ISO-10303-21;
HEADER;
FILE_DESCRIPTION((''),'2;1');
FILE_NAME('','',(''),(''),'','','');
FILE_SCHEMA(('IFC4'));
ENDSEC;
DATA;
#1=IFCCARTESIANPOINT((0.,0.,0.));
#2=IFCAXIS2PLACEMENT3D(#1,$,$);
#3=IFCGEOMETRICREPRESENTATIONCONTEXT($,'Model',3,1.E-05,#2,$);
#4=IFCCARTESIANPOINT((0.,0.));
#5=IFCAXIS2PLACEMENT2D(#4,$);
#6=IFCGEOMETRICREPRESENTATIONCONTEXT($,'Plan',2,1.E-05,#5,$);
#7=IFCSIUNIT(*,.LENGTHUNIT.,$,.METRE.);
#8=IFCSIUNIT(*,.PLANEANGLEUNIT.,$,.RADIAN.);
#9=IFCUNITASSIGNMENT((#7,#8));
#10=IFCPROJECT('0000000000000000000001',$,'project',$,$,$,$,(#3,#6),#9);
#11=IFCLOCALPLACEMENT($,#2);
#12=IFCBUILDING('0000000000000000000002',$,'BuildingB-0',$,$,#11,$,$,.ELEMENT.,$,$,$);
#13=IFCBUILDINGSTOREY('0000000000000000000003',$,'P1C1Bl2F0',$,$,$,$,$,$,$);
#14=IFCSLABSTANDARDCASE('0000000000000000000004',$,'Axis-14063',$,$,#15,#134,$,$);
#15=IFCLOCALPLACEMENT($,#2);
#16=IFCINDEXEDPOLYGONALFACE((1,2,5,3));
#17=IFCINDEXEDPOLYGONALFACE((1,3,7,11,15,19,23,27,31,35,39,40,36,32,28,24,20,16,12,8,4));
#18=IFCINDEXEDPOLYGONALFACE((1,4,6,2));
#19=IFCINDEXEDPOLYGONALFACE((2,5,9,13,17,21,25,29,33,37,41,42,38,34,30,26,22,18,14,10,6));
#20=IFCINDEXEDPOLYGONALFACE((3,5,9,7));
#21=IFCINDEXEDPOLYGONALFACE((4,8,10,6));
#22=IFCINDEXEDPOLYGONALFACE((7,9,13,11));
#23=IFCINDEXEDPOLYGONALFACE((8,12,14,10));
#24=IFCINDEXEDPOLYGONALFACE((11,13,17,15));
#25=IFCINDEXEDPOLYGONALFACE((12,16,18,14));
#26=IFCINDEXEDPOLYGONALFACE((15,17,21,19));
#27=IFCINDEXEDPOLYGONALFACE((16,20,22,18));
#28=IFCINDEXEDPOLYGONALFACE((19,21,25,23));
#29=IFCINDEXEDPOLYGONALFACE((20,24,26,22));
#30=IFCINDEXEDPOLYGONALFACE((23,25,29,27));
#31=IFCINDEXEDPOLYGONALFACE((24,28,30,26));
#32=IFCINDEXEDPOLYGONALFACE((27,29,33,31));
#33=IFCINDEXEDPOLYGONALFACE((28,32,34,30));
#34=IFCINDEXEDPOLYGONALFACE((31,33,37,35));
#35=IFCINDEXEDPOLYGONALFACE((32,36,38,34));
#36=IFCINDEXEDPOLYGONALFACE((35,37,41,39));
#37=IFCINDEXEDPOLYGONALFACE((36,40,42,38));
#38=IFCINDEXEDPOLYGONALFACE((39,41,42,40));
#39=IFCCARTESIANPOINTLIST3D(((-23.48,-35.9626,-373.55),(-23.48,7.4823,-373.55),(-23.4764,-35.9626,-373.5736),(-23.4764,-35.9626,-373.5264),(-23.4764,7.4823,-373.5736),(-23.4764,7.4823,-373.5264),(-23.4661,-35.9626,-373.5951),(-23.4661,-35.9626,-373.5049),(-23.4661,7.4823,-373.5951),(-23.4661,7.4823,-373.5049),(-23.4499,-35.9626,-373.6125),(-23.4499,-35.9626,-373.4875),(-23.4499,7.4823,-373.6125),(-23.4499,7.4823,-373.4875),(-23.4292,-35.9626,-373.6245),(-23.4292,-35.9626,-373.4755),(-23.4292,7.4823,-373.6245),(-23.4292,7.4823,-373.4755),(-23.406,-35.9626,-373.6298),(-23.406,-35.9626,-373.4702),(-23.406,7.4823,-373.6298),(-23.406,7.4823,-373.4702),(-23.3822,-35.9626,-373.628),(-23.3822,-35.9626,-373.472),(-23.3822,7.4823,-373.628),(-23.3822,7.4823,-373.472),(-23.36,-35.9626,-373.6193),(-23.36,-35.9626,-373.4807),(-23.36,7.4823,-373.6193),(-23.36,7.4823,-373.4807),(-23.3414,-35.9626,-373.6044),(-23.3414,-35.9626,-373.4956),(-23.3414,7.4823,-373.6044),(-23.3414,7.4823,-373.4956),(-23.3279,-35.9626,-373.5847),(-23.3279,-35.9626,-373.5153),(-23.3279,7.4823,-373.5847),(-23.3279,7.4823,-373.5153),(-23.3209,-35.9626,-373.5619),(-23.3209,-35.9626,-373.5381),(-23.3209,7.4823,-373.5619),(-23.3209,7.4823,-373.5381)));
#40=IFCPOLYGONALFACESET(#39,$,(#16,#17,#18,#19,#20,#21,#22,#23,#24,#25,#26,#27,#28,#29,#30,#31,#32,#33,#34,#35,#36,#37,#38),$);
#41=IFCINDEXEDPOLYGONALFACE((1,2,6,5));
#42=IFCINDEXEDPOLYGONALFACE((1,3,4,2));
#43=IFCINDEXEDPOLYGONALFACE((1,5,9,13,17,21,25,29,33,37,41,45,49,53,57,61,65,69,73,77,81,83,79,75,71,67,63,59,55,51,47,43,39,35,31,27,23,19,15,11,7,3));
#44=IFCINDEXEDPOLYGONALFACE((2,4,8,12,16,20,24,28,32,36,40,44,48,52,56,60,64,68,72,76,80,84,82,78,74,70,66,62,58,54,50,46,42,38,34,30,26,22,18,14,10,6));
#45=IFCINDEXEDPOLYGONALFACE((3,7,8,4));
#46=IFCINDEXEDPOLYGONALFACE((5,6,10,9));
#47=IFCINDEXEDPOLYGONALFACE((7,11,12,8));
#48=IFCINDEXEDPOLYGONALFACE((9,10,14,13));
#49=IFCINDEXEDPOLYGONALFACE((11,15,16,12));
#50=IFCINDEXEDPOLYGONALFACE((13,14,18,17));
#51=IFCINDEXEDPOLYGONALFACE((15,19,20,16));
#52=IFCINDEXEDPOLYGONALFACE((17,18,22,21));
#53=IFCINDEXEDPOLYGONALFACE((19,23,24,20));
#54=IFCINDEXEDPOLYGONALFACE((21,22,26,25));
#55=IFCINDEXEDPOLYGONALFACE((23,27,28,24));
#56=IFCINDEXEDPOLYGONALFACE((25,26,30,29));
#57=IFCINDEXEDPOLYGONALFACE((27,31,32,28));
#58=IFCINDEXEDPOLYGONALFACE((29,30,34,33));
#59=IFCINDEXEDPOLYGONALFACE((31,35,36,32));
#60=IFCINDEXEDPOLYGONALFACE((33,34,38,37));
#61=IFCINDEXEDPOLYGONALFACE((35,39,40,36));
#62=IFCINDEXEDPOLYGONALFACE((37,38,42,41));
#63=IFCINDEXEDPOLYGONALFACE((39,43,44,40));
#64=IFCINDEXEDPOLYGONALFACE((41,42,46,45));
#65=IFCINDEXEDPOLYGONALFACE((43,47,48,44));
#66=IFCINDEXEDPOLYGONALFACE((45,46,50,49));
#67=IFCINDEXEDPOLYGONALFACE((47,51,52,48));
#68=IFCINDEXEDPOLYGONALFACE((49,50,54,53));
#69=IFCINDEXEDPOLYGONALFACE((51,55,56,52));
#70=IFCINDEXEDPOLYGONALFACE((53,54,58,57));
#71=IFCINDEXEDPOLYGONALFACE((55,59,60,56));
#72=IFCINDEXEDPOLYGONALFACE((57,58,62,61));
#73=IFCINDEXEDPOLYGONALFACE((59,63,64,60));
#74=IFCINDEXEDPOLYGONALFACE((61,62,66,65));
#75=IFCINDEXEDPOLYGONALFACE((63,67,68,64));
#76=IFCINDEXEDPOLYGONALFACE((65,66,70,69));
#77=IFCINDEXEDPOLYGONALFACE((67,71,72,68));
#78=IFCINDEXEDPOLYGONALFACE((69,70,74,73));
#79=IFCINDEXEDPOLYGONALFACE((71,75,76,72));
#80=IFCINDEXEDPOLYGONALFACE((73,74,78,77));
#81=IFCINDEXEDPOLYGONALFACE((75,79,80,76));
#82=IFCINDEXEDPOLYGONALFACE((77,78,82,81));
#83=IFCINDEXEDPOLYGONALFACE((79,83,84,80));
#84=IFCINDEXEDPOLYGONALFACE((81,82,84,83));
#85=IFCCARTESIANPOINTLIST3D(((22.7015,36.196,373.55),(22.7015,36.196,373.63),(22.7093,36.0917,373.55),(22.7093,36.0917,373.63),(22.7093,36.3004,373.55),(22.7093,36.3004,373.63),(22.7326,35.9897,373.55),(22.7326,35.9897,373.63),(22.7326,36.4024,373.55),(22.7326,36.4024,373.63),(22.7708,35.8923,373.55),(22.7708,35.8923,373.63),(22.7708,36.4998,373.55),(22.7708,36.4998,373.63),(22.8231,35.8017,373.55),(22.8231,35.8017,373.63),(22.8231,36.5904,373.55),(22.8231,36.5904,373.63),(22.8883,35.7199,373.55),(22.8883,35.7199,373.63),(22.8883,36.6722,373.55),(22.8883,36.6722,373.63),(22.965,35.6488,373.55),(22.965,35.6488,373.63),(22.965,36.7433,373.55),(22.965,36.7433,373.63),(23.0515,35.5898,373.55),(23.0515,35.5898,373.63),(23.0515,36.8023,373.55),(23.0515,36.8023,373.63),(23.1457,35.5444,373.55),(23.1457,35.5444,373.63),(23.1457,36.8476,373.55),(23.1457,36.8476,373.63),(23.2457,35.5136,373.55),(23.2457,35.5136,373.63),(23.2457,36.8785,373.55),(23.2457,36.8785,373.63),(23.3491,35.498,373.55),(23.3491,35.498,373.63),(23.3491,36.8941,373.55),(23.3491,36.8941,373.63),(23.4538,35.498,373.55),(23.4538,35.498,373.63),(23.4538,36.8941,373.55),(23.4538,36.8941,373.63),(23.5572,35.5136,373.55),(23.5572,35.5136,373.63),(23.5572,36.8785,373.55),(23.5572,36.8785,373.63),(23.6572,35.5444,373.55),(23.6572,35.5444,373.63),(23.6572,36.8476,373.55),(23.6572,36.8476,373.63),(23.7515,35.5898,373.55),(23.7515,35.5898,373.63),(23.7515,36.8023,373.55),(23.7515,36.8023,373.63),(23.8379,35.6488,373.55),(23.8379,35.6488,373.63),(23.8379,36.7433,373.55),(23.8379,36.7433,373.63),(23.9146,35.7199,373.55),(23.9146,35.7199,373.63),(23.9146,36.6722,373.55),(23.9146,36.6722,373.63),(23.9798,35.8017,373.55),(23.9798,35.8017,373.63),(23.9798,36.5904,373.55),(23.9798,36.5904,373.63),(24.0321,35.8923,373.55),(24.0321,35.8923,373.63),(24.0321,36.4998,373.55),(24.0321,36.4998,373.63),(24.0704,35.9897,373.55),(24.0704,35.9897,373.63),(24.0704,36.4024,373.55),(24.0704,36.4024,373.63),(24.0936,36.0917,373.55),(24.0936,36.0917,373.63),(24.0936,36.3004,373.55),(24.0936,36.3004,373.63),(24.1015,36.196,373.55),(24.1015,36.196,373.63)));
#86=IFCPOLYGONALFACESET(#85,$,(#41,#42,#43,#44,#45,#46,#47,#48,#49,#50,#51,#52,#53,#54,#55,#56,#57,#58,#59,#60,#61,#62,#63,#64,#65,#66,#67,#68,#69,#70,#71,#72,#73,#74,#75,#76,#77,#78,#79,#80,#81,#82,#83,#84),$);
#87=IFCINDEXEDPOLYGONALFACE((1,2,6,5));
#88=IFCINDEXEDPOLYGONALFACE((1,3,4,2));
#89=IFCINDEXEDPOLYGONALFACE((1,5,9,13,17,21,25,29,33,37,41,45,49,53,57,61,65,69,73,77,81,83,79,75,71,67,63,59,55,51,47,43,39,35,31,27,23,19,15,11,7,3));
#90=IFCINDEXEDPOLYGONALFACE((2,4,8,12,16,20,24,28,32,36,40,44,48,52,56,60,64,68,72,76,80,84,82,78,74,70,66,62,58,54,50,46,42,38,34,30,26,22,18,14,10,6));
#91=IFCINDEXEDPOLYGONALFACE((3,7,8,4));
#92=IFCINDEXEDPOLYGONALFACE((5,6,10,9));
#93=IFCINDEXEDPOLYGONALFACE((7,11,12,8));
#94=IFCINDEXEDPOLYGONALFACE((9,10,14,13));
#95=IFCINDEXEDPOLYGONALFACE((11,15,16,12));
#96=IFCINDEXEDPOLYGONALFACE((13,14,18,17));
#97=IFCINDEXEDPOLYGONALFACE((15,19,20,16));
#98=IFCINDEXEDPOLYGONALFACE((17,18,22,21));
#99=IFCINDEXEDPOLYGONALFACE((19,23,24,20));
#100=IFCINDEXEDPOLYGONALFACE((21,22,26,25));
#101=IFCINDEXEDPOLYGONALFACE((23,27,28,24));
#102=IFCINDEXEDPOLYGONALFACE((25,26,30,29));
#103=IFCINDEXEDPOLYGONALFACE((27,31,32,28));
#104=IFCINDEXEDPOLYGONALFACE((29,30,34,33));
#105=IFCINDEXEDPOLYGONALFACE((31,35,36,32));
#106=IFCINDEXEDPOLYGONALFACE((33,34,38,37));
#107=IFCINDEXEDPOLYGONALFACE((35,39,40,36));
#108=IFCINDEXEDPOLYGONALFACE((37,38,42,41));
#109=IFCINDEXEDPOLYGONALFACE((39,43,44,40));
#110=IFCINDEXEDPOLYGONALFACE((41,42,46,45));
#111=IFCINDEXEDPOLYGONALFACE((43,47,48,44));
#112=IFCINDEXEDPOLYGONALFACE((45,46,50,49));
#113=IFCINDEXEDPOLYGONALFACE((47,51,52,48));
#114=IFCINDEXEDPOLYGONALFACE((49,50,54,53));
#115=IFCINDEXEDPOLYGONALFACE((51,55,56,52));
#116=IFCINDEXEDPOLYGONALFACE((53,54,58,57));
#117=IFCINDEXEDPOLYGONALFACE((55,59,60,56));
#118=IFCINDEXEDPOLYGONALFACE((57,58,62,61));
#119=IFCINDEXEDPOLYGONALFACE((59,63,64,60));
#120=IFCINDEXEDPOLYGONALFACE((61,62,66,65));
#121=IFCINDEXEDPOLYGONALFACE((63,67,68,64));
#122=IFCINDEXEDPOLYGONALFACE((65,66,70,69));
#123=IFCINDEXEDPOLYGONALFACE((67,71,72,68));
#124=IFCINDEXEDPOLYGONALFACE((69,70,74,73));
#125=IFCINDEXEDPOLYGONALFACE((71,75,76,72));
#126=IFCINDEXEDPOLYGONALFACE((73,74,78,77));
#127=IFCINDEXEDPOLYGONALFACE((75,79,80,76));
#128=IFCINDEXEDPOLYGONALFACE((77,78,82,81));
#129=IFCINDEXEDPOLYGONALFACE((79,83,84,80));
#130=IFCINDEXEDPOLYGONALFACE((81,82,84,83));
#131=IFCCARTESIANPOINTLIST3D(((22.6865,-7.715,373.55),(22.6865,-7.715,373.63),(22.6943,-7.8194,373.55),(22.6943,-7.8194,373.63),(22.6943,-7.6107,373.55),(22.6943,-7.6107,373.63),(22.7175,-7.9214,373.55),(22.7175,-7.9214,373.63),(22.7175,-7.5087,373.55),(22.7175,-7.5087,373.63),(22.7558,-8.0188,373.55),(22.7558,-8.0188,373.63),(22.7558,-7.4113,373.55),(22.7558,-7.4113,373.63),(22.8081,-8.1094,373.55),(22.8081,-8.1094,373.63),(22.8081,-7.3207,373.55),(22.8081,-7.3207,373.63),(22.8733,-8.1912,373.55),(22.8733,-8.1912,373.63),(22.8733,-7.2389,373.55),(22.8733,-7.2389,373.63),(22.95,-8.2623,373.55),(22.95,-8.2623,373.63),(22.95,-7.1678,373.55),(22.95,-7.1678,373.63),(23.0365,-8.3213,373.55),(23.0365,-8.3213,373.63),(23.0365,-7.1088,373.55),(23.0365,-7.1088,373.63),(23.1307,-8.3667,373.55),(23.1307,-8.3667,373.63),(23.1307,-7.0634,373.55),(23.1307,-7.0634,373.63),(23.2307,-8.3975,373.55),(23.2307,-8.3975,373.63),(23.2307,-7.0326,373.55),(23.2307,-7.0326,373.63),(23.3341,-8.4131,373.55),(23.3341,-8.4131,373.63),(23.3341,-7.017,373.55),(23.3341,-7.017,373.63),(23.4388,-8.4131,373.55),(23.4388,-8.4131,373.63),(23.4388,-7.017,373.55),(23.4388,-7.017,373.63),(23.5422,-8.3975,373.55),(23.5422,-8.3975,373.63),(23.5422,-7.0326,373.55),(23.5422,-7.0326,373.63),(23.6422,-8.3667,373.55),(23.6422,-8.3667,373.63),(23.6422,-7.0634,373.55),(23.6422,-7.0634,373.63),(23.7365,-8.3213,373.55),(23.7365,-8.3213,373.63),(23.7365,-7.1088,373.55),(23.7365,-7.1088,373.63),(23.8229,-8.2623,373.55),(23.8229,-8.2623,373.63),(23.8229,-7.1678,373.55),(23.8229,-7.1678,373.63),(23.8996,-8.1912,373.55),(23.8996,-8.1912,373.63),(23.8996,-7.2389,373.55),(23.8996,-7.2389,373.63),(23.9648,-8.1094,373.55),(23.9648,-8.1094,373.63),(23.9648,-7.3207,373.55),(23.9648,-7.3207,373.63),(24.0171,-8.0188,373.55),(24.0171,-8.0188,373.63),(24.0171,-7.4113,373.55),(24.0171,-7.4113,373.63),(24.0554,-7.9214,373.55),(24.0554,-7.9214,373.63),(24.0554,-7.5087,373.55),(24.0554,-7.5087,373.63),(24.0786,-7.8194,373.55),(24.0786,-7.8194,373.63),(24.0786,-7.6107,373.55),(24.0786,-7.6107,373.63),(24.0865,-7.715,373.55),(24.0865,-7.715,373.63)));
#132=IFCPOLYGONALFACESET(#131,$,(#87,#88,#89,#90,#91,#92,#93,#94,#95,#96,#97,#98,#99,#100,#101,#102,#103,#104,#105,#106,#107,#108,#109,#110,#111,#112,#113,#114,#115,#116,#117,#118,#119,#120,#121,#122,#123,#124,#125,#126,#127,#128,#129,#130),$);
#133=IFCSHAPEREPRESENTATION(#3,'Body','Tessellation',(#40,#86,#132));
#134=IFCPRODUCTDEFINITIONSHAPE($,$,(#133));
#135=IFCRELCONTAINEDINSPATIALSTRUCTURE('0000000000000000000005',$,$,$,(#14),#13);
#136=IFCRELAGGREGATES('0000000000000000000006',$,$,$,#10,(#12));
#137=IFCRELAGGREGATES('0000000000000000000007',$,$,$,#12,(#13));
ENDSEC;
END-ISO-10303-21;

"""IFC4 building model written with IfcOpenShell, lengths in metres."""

from ifc_helpers import new_model, entity, si_unit, frame, origin, origin_2d, place, context, project, spatial, circle, extrude, element, save


model = new_model("IFC4")

# Units and contexts
model_context = context("Model", 3, precision=1e-05, world=origin())
plan_context = context("Plan", 2, precision=1e-05, world=origin_2d())
ifc_project = project(units=[si_unit("LENGTHUNIT", "METRE"), si_unit("PLANEANGLEUNIT", "RADIAN")], contexts=[model_context, plan_context])

# Building, storey
building_placement = place(None, origin())
building = spatial("IfcBuilding", under=ifc_project, at=building_placement, Name="BuildingB-0", CompositionType="ELEMENT")
storey = spatial("IfcBuildingStorey", under=building, Name="P1C1Bl2F0")

# Slab
element("IfcSlabStandardCase", 1, inside=storey, Name="Axis-14063", context=model_context, shape_type="AdvancedSweptSolid", body=[
    entity("IfcSurfaceCurveSweptAreaSolid", entity("IfcCircleProfileDef", "AREA", None, None, 0.08), None, entity("IfcPolyline", [entity("IfcCartesianPoint", [23.4, 35.9626, 373.55]), entity("IfcCartesianPoint", [23.4, -7.4823, 373.55])]), None, None, entity("IfcPlane", entity("IfcAxis2Placement3D", entity("IfcCartesianPoint", [23.4, 35.9626, 373.55]), entity("IfcDirection", [0.0, 0.0, 1.0]), entity("IfcDirection", [1.0, 0.0, 0.0])))),
    extrude(circle(Radius=0.7), frame((23.4015, 36.196, 373.55)), (0.0, 0.0, 1.0), 0.08),
    extrude(circle(Radius=0.7), frame((23.3865, -7.715, 373.55)), (0.0, 0.0, 1.0), 0.08),
])

save(model, "model.ifc")
